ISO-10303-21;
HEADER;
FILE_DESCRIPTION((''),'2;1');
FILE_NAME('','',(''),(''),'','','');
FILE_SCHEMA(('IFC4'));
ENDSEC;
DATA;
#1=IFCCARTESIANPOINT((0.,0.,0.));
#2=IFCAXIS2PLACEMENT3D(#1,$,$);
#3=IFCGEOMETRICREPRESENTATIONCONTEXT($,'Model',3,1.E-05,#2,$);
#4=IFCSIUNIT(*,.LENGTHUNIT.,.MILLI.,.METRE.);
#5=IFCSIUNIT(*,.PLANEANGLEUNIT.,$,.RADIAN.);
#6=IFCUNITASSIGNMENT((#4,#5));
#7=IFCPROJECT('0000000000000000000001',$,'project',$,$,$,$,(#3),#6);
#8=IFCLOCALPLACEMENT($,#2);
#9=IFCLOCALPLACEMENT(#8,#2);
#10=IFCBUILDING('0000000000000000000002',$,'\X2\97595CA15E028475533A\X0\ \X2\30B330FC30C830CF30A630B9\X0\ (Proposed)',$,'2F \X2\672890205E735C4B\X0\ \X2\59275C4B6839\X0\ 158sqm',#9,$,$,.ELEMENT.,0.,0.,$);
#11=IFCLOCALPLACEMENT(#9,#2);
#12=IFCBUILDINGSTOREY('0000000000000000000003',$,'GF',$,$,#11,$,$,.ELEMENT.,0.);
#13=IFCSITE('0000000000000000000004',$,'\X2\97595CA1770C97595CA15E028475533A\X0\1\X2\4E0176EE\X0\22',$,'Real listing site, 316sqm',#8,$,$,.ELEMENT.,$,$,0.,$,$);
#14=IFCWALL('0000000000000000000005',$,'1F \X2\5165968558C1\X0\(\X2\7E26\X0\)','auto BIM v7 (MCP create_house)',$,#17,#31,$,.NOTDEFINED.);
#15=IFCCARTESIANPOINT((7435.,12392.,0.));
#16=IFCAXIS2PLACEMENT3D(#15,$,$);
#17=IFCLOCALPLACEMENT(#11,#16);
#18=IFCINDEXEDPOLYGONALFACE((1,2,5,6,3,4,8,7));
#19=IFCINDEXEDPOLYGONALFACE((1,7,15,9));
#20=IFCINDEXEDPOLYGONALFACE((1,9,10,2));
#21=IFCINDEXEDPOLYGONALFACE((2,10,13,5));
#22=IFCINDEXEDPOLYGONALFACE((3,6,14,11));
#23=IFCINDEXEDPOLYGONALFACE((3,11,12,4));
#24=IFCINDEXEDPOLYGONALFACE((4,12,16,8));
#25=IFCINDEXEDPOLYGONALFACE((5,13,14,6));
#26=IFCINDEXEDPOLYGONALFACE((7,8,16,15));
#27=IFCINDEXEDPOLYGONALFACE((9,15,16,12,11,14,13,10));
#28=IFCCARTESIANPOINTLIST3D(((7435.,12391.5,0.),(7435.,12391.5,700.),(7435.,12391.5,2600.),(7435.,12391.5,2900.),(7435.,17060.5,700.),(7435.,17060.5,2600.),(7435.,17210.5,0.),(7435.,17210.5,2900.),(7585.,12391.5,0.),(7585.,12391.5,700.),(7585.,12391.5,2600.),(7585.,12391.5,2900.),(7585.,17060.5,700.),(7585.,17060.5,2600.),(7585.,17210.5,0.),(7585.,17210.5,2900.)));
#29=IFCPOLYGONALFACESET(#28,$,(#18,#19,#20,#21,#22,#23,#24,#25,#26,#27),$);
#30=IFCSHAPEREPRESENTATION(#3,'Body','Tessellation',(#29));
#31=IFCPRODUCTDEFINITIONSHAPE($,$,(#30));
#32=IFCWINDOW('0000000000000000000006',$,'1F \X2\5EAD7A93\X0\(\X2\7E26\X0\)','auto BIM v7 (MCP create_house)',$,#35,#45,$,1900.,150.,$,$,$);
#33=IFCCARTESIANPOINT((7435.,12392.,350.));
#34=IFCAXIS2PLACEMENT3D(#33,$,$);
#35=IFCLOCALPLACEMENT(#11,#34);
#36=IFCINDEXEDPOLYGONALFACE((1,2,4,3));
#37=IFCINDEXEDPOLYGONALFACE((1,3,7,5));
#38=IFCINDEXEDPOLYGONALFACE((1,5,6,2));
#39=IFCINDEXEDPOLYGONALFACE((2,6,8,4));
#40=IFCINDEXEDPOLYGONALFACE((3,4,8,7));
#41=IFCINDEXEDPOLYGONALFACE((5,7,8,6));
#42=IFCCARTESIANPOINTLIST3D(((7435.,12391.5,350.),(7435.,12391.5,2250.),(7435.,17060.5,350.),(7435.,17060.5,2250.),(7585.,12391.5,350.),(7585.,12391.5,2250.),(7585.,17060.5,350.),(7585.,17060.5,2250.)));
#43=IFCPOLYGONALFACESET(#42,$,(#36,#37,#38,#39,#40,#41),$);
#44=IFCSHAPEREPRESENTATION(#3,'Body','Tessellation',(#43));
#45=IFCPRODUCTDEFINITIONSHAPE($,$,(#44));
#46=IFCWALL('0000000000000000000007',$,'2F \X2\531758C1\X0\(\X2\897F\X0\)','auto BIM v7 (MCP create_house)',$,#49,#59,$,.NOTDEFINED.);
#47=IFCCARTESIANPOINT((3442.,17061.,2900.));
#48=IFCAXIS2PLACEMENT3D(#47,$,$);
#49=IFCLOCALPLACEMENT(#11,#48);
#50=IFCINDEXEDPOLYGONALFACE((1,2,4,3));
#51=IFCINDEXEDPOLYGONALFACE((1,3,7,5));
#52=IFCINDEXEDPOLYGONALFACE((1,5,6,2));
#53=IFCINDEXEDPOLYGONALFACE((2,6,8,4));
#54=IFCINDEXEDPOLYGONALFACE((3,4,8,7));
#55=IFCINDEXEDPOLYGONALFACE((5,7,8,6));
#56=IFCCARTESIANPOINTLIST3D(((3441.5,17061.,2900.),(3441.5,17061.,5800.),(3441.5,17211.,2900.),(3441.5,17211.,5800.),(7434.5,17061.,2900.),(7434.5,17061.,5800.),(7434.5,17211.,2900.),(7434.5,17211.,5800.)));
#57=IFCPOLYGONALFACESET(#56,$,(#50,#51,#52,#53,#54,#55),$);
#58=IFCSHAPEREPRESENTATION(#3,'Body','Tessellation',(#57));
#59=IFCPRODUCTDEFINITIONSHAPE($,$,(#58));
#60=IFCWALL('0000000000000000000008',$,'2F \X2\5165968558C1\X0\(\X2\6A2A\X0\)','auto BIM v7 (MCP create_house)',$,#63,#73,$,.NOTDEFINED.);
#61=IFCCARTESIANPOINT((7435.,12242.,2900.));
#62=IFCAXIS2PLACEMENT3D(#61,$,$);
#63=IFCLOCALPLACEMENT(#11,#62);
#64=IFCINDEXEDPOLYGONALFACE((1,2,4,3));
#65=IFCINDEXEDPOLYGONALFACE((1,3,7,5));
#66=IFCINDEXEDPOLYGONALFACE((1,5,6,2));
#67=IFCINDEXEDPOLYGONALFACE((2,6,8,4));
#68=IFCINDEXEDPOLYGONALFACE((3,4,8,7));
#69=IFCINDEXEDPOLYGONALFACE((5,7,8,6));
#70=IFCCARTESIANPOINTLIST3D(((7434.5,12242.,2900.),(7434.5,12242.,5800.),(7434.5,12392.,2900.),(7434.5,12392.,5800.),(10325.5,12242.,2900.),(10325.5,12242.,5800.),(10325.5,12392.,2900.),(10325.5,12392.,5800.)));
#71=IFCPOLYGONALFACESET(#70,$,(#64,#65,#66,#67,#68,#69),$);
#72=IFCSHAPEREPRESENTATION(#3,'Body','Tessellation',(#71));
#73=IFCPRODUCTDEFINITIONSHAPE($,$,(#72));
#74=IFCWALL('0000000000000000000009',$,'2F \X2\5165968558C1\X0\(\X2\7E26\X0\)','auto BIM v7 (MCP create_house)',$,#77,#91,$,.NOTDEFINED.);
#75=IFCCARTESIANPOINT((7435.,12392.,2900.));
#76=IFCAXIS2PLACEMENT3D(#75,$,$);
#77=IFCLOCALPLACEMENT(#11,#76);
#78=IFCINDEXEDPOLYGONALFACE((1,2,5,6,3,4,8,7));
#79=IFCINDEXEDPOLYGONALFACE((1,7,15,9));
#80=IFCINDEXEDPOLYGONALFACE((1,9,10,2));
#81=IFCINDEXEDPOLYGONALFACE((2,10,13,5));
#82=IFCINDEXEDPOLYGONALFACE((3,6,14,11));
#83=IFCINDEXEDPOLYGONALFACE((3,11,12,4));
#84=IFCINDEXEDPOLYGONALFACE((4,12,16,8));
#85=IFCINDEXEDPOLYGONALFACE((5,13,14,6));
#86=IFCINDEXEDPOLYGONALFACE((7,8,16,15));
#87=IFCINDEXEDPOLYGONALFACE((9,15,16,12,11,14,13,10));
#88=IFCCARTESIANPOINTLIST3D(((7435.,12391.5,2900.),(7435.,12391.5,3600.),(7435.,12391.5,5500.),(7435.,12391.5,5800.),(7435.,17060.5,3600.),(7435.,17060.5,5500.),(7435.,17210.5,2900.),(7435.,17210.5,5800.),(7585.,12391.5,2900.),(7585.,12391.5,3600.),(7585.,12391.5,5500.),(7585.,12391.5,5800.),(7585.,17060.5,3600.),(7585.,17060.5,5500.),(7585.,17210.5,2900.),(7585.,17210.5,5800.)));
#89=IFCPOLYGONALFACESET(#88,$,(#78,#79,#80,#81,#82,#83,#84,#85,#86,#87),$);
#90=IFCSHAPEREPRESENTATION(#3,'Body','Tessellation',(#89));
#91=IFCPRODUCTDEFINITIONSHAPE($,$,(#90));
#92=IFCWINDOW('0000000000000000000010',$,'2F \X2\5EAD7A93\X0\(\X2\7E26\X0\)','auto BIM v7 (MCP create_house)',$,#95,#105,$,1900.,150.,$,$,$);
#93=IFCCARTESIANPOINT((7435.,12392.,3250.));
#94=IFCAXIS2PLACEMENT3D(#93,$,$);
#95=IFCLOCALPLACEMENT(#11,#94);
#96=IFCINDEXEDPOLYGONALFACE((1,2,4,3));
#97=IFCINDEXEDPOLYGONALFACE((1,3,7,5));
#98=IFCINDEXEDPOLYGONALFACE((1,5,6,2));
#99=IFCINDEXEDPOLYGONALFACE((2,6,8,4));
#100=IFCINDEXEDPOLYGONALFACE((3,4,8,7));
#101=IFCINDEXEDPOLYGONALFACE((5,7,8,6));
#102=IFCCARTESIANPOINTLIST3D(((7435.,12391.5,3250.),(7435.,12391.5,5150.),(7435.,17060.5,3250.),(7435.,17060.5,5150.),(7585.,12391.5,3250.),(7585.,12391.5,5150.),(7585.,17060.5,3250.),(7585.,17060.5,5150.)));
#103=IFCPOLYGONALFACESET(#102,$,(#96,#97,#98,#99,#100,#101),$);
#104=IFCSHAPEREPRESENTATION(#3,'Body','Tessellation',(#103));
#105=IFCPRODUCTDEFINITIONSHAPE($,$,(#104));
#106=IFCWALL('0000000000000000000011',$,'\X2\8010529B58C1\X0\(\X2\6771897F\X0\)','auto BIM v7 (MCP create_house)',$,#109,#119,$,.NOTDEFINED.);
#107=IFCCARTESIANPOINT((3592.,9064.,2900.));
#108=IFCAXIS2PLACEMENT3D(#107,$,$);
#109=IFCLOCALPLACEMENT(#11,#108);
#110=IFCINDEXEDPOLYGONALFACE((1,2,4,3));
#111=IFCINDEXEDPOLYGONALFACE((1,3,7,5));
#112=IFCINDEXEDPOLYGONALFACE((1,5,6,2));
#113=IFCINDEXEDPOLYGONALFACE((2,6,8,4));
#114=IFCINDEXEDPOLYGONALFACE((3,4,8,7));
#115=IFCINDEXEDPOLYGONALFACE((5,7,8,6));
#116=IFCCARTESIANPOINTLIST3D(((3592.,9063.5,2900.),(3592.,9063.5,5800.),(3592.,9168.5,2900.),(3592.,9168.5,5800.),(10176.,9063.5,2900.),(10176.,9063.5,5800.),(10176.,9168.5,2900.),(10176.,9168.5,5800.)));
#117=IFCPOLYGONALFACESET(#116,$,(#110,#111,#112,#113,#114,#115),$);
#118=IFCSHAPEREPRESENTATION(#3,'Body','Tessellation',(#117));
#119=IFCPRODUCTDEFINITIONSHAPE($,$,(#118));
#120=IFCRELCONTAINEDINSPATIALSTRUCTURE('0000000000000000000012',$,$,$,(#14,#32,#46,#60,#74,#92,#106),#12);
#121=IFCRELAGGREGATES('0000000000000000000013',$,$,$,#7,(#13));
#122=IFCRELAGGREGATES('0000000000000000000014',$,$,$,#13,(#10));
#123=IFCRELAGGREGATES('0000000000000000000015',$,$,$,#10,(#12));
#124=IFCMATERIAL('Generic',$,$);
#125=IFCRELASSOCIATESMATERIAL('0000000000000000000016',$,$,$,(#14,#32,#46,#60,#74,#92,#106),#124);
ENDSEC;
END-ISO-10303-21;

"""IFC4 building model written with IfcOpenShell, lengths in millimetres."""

from ifc_helpers import new_model, si_unit, frame, frame_2d, origin, place, context, project, spatial, rectangle, extrude, material, element, fill, save


model = new_model("IFC4")

# Units and contexts
model_context = context("Model", 3, precision=1e-05, world=origin())
ifc_project = project(units=[si_unit("LENGTHUNIT", "METRE", prefix="MILLI"), si_unit("PLANEANGLEUNIT", "RADIAN")], contexts=[model_context])

# Site, building, storey
site_placement = place(None, origin())
site = spatial("IfcSite", under=ifc_project, at=site_placement, Name="静岡県静岡市葵区1丁目22", ObjectType="Real listing site, 316sqm", CompositionType="ELEMENT", RefElevation=0.0)
building_placement = place(site_placement, origin())
building = spatial("IfcBuilding", under=site, at=building_placement, Name="静岡市葵区 コートハウス (Proposed)", ObjectType="2F 木造平屋 大屋根 158sqm", CompositionType="ELEMENT", ElevationOfRefHeight=0.0, ElevationOfTerrain=0.0)
storey_placement = place(building_placement, origin())
storey = spatial("IfcBuildingStorey", under=building, at=storey_placement, Name="GF", CompositionType="ELEMENT", Elevation=0.0)

# Shared definitions
ifc_material = material(Name="Generic")

# Wall, opening, window
wall_1_placement = place(storey_placement, frame((7435.0, 12392.0, 0.0)))
wall_1 = element("IfcWall", 1, at=wall_1_placement, inside=storey, material=ifc_material, Name="1F 入隅壁(縦)", Description="auto BIM v7 (MCP create_house)", PredefinedType="NOTDEFINED", context=model_context, shape_type="SweptSolid", body=[
    extrude(rectangle(XDim=150.0, YDim=4819.0, at=frame_2d((75.0, 2409.0))), frame((7435.0, 12392.0, 0.0)), (0.0, 0.0, 1.0), 2900.0),
])
opening_1_placement = place(storey_placement, frame((7435.0, 12392.0, 350.0)))
opening_1 = element("IfcOpeningElement", 2, at=opening_1_placement, cuts=wall_1, PredefinedType="NOTDEFINED", context=model_context, shape_type="SweptSolid", body=[
    extrude(rectangle(XDim=150.0, YDim=4669.0, at=frame_2d((75.0, 2334.0))), frame((7435.0, 12392.0, 350.0)), (0.0, 0.0, 1.0), 1900.0),
])
window_1_placement = place(storey_placement, frame((7435.0, 12392.0, 350.0)))
window_1 = element("IfcWindow", 3, at=window_1_placement, inside=storey, material=ifc_material, Name="1F 庭窓(縦)", Description="auto BIM v7 (MCP create_house)", OverallHeight=1900.0, OverallWidth=150.0, context=model_context, shape_type="SweptSolid", body=[
    extrude(rectangle(XDim=150.0, YDim=4669.0, at=frame_2d((75.0, 2334.0))), frame((7435.0, 12392.0, 350.0)), (0.0, 0.0, 1.0), 1900.0),
])
fill(opening_1, window_1)

# Walls
wall_2_placement = place(storey_placement, frame((3442.0, 17061.0, 2900.0)))
element("IfcWall", 4, at=wall_2_placement, inside=storey, material=ifc_material, Name="2F 北壁(西)", Description="auto BIM v7 (MCP create_house)", PredefinedType="NOTDEFINED", context=model_context, shape_type="SweptSolid", body=[
    extrude(rectangle(XDim=3993.0, YDim=150.0, at=frame_2d((1996.0, 75.0))), frame((3442.0, 17061.0, 2900.0)), (0.0, 0.0, 1.0), 2900.0),
])
wall_3_placement = place(storey_placement, frame((7435.0, 12242.0, 2900.0)))
element("IfcWall", 5, at=wall_3_placement, inside=storey, material=ifc_material, Name="2F 入隅壁(横)", Description="auto BIM v7 (MCP create_house)", PredefinedType="NOTDEFINED", context=model_context, shape_type="SweptSolid", body=[
    extrude(rectangle(XDim=2891.0, YDim=150.0, at=frame_2d((1445.0, 75.0))), frame((7435.0, 12242.0, 2900.0)), (0.0, 0.0, 1.0), 2900.0),
])

# Wall, opening, window
wall_4_placement = place(storey_placement, frame((7435.0, 12392.0, 2900.0)))
wall_4 = element("IfcWall", 6, at=wall_4_placement, inside=storey, material=ifc_material, Name="2F 入隅壁(縦)", Description="auto BIM v7 (MCP create_house)", PredefinedType="NOTDEFINED", context=model_context, shape_type="SweptSolid", body=[
    extrude(rectangle(XDim=150.0, YDim=4819.0, at=frame_2d((75.0, 2409.0))), frame((7435.0, 12392.0, 2900.0)), (0.0, 0.0, 1.0), 2900.0),
])
opening_2_placement = place(storey_placement, frame((7435.0, 12392.0, 3250.0)))
opening_2 = element("IfcOpeningElement", 7, at=opening_2_placement, cuts=wall_4, PredefinedType="NOTDEFINED", context=model_context, shape_type="SweptSolid", body=[
    extrude(rectangle(XDim=150.0, YDim=4669.0, at=frame_2d((75.0, 2334.0))), frame((7435.0, 12392.0, 3250.0)), (0.0, 0.0, 1.0), 1900.0),
])
window_2_placement = place(storey_placement, frame((7435.0, 12392.0, 3250.0)))
window_2 = element("IfcWindow", 8, at=window_2_placement, inside=storey, material=ifc_material, Name="2F 庭窓(縦)", Description="auto BIM v7 (MCP create_house)", OverallHeight=1900.0, OverallWidth=150.0, context=model_context, shape_type="SweptSolid", body=[
    extrude(rectangle(XDim=150.0, YDim=4669.0, at=frame_2d((75.0, 2334.0))), frame((7435.0, 12392.0, 3250.0)), (0.0, 0.0, 1.0), 1900.0),
])
fill(opening_2, window_2)

# Wall
wall_5_placement = place(storey_placement, frame((3592.0, 9064.0, 2900.0)))
element("IfcWall", 9, at=wall_5_placement, inside=storey, material=ifc_material, Name="耐力壁(東西)", Description="auto BIM v7 (MCP create_house)", PredefinedType="NOTDEFINED", context=model_context, shape_type="SweptSolid", body=[
    extrude(rectangle(XDim=6584.0, YDim=105.0, at=frame_2d((3292.0, 52.0))), frame((3592.0, 9064.0, 2900.0)), (0.0, 0.0, 1.0), 2900.0),
])

save(model, "model.ifc")
